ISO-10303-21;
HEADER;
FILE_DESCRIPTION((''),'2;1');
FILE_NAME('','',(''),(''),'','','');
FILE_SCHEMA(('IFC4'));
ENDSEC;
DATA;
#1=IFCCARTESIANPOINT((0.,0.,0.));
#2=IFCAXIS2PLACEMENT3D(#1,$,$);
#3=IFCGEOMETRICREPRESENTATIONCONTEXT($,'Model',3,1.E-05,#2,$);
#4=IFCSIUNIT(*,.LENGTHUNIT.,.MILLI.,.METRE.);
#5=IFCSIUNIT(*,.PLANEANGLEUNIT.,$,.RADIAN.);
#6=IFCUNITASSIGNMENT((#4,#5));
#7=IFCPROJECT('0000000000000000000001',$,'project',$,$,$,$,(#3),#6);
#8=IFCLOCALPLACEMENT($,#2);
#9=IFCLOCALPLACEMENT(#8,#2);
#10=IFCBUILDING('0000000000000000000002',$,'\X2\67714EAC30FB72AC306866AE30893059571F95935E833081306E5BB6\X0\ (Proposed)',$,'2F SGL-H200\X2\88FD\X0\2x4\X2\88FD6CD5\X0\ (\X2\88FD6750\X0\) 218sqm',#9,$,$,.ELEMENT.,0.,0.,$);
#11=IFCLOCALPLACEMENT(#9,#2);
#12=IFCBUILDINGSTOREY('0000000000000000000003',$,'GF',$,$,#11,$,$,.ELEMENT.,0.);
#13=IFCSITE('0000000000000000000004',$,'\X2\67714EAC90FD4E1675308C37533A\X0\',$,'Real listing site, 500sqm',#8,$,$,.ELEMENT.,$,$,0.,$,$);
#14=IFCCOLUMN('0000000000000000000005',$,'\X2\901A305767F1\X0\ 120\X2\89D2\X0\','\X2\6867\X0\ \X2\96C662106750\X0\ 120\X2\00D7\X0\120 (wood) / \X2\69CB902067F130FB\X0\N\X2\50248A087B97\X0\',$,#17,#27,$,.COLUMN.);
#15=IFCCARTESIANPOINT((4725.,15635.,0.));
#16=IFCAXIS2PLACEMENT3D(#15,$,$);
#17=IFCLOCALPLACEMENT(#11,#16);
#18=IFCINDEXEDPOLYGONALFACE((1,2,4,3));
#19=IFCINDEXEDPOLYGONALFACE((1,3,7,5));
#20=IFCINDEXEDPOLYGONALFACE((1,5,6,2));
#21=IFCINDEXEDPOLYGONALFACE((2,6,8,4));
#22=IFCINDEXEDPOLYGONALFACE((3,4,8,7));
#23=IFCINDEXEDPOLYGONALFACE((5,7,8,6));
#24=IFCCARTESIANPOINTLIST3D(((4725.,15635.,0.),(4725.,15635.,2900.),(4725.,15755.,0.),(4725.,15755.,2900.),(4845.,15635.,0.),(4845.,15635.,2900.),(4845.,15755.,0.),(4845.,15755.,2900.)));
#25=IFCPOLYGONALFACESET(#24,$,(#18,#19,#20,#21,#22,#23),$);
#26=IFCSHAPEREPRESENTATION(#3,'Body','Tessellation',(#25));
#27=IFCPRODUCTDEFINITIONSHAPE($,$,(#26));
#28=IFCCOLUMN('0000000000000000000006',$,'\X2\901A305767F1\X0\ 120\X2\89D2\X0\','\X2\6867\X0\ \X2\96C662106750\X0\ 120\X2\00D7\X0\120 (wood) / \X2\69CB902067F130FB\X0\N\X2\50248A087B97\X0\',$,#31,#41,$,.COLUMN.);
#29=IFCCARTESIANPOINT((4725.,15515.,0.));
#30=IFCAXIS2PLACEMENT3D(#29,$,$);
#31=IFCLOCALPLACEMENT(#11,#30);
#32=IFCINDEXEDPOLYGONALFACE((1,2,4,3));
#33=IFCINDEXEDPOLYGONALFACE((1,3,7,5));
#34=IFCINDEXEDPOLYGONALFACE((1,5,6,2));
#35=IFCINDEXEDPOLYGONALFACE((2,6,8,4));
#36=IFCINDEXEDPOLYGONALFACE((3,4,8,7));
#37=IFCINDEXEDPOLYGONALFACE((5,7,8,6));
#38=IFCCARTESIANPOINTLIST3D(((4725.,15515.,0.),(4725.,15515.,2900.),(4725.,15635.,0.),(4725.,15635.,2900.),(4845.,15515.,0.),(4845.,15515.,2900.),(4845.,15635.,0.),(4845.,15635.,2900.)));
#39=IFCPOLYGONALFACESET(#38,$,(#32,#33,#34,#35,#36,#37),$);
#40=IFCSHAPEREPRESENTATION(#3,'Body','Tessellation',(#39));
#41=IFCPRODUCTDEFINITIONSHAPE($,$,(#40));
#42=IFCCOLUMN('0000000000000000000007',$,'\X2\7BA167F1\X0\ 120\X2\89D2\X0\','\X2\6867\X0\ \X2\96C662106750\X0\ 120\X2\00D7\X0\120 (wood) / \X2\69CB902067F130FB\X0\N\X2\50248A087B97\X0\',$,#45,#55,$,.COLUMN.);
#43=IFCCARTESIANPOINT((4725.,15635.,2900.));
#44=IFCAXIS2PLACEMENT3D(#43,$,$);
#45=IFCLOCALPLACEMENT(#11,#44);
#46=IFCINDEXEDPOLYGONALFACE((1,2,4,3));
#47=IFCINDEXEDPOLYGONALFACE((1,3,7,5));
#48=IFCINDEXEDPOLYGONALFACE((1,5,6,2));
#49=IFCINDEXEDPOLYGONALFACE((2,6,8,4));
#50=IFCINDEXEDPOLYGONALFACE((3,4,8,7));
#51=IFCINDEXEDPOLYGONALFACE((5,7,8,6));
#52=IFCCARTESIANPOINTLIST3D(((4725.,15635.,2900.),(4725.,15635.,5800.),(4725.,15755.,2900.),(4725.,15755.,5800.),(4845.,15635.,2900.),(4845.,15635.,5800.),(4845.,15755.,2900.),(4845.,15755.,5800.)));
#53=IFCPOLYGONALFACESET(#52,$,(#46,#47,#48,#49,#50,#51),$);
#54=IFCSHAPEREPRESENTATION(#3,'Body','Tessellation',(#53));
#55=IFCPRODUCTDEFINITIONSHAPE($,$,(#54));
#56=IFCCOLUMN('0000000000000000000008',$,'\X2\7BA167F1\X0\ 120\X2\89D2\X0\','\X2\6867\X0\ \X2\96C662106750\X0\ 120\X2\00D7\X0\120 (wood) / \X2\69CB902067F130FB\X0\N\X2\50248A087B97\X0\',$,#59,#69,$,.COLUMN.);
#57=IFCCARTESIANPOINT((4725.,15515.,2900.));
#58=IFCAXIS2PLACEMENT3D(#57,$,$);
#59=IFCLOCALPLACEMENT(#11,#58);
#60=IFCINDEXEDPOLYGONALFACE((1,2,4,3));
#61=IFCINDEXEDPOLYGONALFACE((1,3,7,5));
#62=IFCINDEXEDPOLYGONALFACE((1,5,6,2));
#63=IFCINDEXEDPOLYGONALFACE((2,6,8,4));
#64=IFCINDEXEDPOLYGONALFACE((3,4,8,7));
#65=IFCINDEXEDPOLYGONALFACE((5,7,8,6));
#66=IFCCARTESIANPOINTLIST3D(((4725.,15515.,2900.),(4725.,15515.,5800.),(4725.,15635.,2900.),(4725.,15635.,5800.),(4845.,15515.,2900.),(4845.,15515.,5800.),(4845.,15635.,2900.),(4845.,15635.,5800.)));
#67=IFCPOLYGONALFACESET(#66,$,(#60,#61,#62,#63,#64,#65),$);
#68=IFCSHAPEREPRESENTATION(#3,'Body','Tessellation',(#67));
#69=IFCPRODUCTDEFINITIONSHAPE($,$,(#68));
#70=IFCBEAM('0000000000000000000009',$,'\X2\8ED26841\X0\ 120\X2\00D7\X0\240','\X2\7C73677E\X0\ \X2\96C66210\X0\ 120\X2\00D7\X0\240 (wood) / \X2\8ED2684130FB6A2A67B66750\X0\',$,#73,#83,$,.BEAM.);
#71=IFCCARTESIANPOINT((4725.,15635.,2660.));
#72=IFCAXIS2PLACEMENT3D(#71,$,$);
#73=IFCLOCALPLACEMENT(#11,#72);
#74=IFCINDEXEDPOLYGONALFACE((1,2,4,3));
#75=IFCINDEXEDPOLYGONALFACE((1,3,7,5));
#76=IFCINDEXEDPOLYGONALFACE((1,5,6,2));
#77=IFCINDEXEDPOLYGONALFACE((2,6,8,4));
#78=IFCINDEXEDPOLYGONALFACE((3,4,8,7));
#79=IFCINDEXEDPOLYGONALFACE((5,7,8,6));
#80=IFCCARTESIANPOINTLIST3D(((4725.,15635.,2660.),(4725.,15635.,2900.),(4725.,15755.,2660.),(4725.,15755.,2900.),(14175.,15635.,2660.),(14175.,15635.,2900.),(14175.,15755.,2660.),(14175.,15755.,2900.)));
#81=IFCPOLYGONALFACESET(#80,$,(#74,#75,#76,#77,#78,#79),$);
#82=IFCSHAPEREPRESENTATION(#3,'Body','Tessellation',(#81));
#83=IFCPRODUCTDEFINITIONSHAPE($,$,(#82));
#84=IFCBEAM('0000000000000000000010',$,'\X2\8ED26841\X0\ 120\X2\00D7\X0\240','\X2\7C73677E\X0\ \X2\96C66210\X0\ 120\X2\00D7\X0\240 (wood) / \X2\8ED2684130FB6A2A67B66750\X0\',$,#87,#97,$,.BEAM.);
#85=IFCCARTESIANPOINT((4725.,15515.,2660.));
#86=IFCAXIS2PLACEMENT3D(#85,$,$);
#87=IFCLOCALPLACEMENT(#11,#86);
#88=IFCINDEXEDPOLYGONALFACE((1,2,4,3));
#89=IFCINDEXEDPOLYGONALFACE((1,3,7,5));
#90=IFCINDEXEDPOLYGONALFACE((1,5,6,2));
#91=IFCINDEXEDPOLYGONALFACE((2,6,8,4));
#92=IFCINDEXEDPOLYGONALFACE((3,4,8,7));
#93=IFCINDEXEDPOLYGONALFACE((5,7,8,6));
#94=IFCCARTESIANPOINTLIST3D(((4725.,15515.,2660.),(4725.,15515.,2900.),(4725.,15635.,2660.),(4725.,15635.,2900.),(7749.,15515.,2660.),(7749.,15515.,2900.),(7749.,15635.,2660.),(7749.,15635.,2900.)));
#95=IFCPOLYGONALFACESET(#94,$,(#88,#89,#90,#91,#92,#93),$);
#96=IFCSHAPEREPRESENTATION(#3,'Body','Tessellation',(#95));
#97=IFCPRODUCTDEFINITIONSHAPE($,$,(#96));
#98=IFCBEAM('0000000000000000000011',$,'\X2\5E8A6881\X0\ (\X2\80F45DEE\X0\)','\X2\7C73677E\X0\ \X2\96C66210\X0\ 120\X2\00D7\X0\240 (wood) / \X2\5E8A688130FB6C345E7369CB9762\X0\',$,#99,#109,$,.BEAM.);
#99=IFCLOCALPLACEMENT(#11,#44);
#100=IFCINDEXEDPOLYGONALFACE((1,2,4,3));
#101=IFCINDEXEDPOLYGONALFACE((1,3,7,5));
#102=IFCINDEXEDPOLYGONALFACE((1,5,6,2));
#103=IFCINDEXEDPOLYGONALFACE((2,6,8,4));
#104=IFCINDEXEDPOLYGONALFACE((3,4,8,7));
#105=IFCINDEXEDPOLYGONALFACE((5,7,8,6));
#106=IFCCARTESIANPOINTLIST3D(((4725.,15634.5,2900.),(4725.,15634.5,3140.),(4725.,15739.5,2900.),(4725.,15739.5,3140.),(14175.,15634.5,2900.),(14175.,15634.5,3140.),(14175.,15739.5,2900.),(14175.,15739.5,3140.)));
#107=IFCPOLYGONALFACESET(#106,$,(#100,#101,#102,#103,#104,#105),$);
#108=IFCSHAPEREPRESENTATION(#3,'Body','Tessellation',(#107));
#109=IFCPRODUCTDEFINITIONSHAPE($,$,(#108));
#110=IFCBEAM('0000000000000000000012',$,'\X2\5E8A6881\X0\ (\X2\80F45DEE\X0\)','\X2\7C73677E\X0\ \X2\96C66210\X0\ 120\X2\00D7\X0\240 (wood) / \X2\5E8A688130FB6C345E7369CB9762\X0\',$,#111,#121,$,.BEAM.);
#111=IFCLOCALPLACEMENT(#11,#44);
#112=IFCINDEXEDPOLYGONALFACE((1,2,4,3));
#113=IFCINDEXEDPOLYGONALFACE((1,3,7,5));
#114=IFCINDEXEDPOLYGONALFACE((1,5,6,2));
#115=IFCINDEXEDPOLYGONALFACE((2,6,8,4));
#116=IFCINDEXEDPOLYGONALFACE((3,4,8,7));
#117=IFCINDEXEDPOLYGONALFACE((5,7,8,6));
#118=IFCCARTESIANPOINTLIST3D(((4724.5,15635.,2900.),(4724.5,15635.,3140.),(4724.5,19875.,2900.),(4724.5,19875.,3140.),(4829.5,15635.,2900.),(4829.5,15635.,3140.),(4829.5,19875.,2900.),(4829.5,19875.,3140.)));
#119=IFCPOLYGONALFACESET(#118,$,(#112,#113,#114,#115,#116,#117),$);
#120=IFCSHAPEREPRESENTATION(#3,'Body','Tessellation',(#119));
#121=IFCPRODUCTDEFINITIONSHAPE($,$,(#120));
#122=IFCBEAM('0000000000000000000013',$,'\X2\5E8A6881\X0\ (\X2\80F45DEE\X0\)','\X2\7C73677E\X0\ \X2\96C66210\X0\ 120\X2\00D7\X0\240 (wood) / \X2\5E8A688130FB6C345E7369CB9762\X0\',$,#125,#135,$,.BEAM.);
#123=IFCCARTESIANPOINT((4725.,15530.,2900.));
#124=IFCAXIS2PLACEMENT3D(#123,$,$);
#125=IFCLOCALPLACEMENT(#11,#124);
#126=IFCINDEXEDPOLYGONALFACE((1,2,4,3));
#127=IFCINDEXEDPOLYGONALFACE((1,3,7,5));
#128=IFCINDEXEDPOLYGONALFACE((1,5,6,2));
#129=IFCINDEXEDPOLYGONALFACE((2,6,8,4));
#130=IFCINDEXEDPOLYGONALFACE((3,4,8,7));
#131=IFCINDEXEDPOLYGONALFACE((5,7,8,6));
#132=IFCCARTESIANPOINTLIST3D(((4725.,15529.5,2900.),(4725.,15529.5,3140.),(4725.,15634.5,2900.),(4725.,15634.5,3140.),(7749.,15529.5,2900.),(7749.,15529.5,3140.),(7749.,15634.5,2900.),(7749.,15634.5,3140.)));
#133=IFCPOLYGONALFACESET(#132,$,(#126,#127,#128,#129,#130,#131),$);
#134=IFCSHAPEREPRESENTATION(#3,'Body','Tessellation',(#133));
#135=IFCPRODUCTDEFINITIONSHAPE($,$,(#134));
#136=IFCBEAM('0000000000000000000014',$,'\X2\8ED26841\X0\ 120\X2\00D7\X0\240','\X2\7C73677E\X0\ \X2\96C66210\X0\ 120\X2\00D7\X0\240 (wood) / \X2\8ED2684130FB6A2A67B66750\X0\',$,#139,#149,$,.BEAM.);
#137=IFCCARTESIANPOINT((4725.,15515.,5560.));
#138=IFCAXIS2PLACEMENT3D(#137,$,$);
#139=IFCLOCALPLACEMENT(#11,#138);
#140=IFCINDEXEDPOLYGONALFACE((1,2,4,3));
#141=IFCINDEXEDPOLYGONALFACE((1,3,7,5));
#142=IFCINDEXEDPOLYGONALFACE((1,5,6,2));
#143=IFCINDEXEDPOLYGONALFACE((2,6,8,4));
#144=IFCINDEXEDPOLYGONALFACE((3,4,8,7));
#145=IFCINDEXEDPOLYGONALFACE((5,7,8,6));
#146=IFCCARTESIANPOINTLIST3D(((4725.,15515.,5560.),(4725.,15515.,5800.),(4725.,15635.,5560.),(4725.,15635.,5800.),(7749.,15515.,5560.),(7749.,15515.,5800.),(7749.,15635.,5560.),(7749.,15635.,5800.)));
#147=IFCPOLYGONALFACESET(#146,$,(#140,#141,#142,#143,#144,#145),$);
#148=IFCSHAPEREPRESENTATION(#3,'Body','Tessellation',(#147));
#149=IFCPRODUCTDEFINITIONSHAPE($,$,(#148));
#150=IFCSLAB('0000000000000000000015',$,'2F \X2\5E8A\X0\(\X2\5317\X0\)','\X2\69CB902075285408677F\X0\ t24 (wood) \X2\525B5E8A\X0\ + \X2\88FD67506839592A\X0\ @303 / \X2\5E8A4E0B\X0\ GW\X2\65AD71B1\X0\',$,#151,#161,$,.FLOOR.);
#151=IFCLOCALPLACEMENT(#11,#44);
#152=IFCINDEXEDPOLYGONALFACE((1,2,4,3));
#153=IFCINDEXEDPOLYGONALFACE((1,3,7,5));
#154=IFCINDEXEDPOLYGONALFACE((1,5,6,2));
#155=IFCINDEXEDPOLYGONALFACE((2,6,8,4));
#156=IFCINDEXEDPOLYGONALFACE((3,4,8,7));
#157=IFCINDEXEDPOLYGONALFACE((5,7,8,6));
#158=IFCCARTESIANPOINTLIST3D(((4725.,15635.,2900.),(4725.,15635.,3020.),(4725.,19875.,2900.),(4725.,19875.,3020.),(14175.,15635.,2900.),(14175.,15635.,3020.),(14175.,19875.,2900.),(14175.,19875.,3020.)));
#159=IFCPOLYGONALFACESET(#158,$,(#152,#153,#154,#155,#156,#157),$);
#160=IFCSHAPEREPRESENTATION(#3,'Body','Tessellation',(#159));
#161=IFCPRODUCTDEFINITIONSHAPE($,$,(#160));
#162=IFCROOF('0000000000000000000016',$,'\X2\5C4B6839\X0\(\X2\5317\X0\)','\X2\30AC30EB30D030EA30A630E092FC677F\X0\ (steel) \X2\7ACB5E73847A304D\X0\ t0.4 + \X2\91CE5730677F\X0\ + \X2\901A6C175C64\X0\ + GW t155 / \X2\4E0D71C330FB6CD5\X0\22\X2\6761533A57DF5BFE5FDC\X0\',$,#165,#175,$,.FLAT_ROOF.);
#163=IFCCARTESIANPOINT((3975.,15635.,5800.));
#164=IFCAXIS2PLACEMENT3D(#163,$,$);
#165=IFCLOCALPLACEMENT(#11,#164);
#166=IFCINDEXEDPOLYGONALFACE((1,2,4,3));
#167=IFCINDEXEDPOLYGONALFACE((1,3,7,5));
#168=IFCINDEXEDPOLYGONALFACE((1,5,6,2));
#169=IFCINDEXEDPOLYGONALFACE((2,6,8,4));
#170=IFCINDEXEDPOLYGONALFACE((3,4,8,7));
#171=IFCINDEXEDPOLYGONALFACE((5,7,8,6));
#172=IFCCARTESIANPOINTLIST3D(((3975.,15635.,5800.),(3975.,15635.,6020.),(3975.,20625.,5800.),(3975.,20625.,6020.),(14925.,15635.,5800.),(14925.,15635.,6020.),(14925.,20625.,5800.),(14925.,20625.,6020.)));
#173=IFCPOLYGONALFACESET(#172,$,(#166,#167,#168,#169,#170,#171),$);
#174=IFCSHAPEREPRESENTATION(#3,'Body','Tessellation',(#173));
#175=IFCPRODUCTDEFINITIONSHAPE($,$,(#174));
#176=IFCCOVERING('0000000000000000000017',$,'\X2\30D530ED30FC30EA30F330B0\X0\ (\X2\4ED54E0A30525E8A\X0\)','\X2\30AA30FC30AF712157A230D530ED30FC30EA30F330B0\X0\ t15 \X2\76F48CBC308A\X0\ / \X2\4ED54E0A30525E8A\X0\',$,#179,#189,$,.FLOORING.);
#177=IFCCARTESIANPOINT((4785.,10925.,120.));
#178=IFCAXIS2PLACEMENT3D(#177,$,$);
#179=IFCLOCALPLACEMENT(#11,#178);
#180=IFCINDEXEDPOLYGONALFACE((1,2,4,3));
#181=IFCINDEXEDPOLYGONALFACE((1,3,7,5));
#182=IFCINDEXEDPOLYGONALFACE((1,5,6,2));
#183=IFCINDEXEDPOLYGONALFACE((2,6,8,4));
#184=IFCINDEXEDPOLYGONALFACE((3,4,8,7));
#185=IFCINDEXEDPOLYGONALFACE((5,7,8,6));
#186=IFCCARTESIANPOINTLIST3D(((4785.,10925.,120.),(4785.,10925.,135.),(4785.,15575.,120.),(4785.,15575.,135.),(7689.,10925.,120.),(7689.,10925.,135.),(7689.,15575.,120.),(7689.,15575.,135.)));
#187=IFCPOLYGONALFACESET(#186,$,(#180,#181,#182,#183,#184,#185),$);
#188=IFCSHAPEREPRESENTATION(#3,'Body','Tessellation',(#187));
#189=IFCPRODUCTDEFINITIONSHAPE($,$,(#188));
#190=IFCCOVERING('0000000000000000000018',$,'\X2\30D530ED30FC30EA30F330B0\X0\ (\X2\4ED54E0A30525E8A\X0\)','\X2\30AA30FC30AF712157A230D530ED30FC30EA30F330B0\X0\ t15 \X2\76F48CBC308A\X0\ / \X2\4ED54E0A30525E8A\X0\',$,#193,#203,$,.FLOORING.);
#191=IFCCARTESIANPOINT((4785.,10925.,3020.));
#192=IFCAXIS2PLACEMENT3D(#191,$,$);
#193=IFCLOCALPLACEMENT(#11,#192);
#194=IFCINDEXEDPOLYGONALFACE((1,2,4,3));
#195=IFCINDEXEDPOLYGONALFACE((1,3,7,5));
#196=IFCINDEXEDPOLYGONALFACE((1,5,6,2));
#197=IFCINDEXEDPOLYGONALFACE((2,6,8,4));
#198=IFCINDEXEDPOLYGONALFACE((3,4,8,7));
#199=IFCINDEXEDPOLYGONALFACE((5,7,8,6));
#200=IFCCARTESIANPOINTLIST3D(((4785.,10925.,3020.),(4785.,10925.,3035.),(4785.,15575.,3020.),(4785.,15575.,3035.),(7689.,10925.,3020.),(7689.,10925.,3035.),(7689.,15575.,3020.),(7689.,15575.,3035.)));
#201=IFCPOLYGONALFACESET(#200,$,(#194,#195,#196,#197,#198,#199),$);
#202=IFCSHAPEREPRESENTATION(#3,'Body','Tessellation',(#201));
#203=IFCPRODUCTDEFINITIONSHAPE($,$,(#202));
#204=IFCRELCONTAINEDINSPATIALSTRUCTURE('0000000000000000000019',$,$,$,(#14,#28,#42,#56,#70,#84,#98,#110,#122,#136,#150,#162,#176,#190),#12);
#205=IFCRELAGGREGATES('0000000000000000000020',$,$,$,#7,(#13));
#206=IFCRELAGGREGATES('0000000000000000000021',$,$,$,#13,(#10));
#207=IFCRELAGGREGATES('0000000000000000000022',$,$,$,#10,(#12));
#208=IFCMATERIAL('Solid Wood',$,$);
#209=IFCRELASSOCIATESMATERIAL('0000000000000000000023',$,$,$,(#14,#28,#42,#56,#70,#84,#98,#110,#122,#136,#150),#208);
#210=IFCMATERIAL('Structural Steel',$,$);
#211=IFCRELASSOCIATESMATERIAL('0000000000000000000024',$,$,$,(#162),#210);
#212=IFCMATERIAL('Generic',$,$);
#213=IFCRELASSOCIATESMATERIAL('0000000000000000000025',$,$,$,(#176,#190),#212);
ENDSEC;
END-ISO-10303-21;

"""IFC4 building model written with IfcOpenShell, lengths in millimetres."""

from ifc_helpers import new_model, si_unit, frame, frame_2d, origin, place, context, project, spatial, rectangle, extrude, material, element, save


model = new_model("IFC4")

# Units and contexts
model_context = context("Model", 3, precision=1e-05, world=origin())
ifc_project = project(units=[si_unit("LENGTHUNIT", "METRE", prefix="MILLI"), si_unit("PLANEANGLEUNIT", "RADIAN")], contexts=[model_context])

# Site, building, storey
site_placement = place(None, origin())
site = spatial("IfcSite", under=ifc_project, at=site_placement, Name="東京都世田谷区", ObjectType="Real listing site, 500sqm", CompositionType="ELEMENT", RefElevation=0.0)
building_placement = place(site_placement, origin())
building = spatial("IfcBuilding", under=site, at=building_placement, Name="東京・犬と暮らす土間広めの家 (Proposed)", ObjectType="2F SGL-H200製2x4製法 (製材) 218sqm", CompositionType="ELEMENT", ElevationOfRefHeight=0.0, ElevationOfTerrain=0.0)
storey_placement = place(building_placement, origin())
storey = spatial("IfcBuildingStorey", under=building, at=storey_placement, Name="GF", CompositionType="ELEMENT", Elevation=0.0)

# Columns
ifc_material_1 = material(Name="Solid Wood")
column_1_placement = place(storey_placement, frame((4725.0, 15635.0, 0.0)))
element("IfcColumn", 1, at=column_1_placement, inside=storey, material=ifc_material_1, Name="通し柱 120角", Description="桧 集成材 120×120 (wood) / 構造柱・N値計算", PredefinedType="COLUMN", context=model_context, shape_type="SweptSolid", body=[
    extrude(rectangle(XDim=120.0, YDim=120.0, at=frame_2d((60.0, 60.0))), frame((4725.0, 15635.0, 0.0)), (0.0, 0.0, 1.0), 2900.0),
])
column_2_placement = place(storey_placement, frame((4725.0, 15515.0, 0.0)))
element("IfcColumn", 2, at=column_2_placement, inside=storey, material=ifc_material_1, Name="通し柱 120角", Description="桧 集成材 120×120 (wood) / 構造柱・N値計算", PredefinedType="COLUMN", context=model_context, shape_type="SweptSolid", body=[
    extrude(rectangle(XDim=120.0, YDim=120.0, at=frame_2d((60.0, 60.0))), frame((4725.0, 15515.0, 0.0)), (0.0, 0.0, 1.0), 2900.0),
])
column_3_placement = place(storey_placement, frame((4725.0, 15635.0, 2900.0)))
element("IfcColumn", 3, at=column_3_placement, inside=storey, material=ifc_material_1, Name="管柱 120角", Description="桧 集成材 120×120 (wood) / 構造柱・N値計算", PredefinedType="COLUMN", context=model_context, shape_type="SweptSolid", body=[
    extrude(rectangle(XDim=120.0, YDim=120.0, at=frame_2d((60.0, 60.0))), frame((4725.0, 15635.0, 2900.0)), (0.0, 0.0, 1.0), 2900.0),
])
column_4_placement = place(storey_placement, frame((4725.0, 15515.0, 2900.0)))
element("IfcColumn", 4, at=column_4_placement, inside=storey, material=ifc_material_1, Name="管柱 120角", Description="桧 集成材 120×120 (wood) / 構造柱・N値計算", PredefinedType="COLUMN", context=model_context, shape_type="SweptSolid", body=[
    extrude(rectangle(XDim=120.0, YDim=120.0, at=frame_2d((60.0, 60.0))), frame((4725.0, 15515.0, 2900.0)), (0.0, 0.0, 1.0), 2900.0),
])

# Beams
beam_1_placement = place(storey_placement, frame((4725.0, 15635.0, 2660.0)))
element("IfcBeam", 5, at=beam_1_placement, inside=storey, material=ifc_material_1, Name="軒桁 120×240", Description="米松 集成 120×240 (wood) / 軒桁・横架材", PredefinedType="BEAM", context=model_context, shape_type="SweptSolid", body=[
    extrude(rectangle(XDim=9450.0, YDim=120.0, at=frame_2d((4725.0, 60.0))), frame((4725.0, 15635.0, 2660.0)), (0.0, 0.0, 1.0), 240.0),
])
beam_2_placement = place(storey_placement, frame((4725.0, 15515.0, 2660.0)))
element("IfcBeam", 6, at=beam_2_placement, inside=storey, material=ifc_material_1, Name="軒桁 120×240", Description="米松 集成 120×240 (wood) / 軒桁・横架材", PredefinedType="BEAM", context=model_context, shape_type="SweptSolid", body=[
    extrude(rectangle(XDim=3024.0, YDim=120.0, at=frame_2d((1512.0, 60.0))), frame((4725.0, 15515.0, 2660.0)), (0.0, 0.0, 1.0), 240.0),
])
beam_3_placement = place(storey_placement, frame((4725.0, 15635.0, 2900.0)))
element("IfcBeam", 7, at=beam_3_placement, inside=storey, material=ifc_material_1, Name="床梁 (胴差)", Description="米松 集成 120×240 (wood) / 床梁・水平構面", PredefinedType="BEAM", context=model_context, shape_type="SweptSolid", body=[
    extrude(rectangle(XDim=9450.0, YDim=105.0, at=frame_2d((4725.0, 52.0))), frame((4725.0, 15635.0, 2900.0)), (0.0, 0.0, 1.0), 240.0),
])
beam_4_placement = place(storey_placement, frame((4725.0, 15635.0, 2900.0)))
element("IfcBeam", 8, at=beam_4_placement, inside=storey, material=ifc_material_1, Name="床梁 (胴差)", Description="米松 集成 120×240 (wood) / 床梁・水平構面", PredefinedType="BEAM", context=model_context, shape_type="SweptSolid", body=[
    extrude(rectangle(XDim=105.0, YDim=4240.0, at=frame_2d((52.0, 2120.0))), frame((4725.0, 15635.0, 2900.0)), (0.0, 0.0, 1.0), 240.0),
])
beam_5_placement = place(storey_placement, frame((4725.0, 15530.0, 2900.0)))
element("IfcBeam", 9, at=beam_5_placement, inside=storey, material=ifc_material_1, Name="床梁 (胴差)", Description="米松 集成 120×240 (wood) / 床梁・水平構面", PredefinedType="BEAM", context=model_context, shape_type="SweptSolid", body=[
    extrude(rectangle(XDim=3024.0, YDim=105.0, at=frame_2d((1512.0, 52.0))), frame((4725.0, 15530.0, 2900.0)), (0.0, 0.0, 1.0), 240.0),
])
beam_6_placement = place(storey_placement, frame((4725.0, 15515.0, 5560.0)))
element("IfcBeam", 10, at=beam_6_placement, inside=storey, material=ifc_material_1, Name="軒桁 120×240", Description="米松 集成 120×240 (wood) / 軒桁・横架材", PredefinedType="BEAM", context=model_context, shape_type="SweptSolid", body=[
    extrude(rectangle(XDim=3024.0, YDim=120.0, at=frame_2d((1512.0, 60.0))), frame((4725.0, 15515.0, 5560.0)), (0.0, 0.0, 1.0), 240.0),
])

# Slab
slab_1_placement = place(storey_placement, frame((4725.0, 15635.0, 2900.0)))
element("IfcSlab", 11, at=slab_1_placement, inside=storey, material=ifc_material_1, Name="2F 床(北)", Description="構造用合板 t24 (wood) 剛床 + 製材根太 @303 / 床下 GW断熱", PredefinedType="FLOOR", context=model_context, shape_type="SweptSolid", body=[
    extrude(rectangle(XDim=9450.0, YDim=4240.0, at=frame_2d((4725.0, 2120.0))), frame((4725.0, 15635.0, 2900.0)), (0.0, 0.0, 1.0), 120.0),
])

# Roof
ifc_material_2 = material(Name="Structural Steel")
for number, where, name in (
    (12, (3975.0, 15635.0, 5800.0), "屋根(北)"),
):
    element("IfcRoof", number, at=place(storey_placement, frame(where)), inside=storey, material=ifc_material_2, Name=name, Description="ガルバリウム鋼板 (steel) 立平葺き t0.4 + 野地板 + 通気層 + GW t155 / 不燃・法22条区域対応", PredefinedType="FLAT_ROOF", context=model_context, shape_type="SweptSolid", body=[
        extrude(rectangle(XDim=10950.0, YDim=4990.0, at=frame_2d((5475.0, 2495.0))), frame((3975.0, 15635.0, 5800.0)), (0.0, 0.0, 1.0), 220.0),
    ])

# Coverings
ifc_material_3 = material(Name="Generic")
covering_1_placement = place(storey_placement, frame((4785.0, 10925.0, 120.0)))
element("IfcCovering", 13, at=covering_1_placement, inside=storey, material=ifc_material_3, Name="フローリング (仕上げ床)", Description="オーク無垢フローリング t15 直貼り / 仕上げ床", PredefinedType="FLOORING", context=model_context, shape_type="SweptSolid", body=[
    extrude(rectangle(XDim=2904.0, YDim=4650.0, at=frame_2d((1452.0, 2325.0))), frame((4785.0, 10925.0, 120.0)), (0.0, 0.0, 1.0), 15.0),
])
covering_2_placement = place(storey_placement, frame((4785.0, 10925.0, 3020.0)))
element("IfcCovering", 14, at=covering_2_placement, inside=storey, material=ifc_material_3, Name="フローリング (仕上げ床)", Description="オーク無垢フローリング t15 直貼り / 仕上げ床", PredefinedType="FLOORING", context=model_context, shape_type="SweptSolid", body=[
    extrude(rectangle(XDim=2904.0, YDim=4650.0, at=frame_2d((1452.0, 2325.0))), frame((4785.0, 10925.0, 3020.0)), (0.0, 0.0, 1.0), 15.0),
])

save(model, "model.ifc")
